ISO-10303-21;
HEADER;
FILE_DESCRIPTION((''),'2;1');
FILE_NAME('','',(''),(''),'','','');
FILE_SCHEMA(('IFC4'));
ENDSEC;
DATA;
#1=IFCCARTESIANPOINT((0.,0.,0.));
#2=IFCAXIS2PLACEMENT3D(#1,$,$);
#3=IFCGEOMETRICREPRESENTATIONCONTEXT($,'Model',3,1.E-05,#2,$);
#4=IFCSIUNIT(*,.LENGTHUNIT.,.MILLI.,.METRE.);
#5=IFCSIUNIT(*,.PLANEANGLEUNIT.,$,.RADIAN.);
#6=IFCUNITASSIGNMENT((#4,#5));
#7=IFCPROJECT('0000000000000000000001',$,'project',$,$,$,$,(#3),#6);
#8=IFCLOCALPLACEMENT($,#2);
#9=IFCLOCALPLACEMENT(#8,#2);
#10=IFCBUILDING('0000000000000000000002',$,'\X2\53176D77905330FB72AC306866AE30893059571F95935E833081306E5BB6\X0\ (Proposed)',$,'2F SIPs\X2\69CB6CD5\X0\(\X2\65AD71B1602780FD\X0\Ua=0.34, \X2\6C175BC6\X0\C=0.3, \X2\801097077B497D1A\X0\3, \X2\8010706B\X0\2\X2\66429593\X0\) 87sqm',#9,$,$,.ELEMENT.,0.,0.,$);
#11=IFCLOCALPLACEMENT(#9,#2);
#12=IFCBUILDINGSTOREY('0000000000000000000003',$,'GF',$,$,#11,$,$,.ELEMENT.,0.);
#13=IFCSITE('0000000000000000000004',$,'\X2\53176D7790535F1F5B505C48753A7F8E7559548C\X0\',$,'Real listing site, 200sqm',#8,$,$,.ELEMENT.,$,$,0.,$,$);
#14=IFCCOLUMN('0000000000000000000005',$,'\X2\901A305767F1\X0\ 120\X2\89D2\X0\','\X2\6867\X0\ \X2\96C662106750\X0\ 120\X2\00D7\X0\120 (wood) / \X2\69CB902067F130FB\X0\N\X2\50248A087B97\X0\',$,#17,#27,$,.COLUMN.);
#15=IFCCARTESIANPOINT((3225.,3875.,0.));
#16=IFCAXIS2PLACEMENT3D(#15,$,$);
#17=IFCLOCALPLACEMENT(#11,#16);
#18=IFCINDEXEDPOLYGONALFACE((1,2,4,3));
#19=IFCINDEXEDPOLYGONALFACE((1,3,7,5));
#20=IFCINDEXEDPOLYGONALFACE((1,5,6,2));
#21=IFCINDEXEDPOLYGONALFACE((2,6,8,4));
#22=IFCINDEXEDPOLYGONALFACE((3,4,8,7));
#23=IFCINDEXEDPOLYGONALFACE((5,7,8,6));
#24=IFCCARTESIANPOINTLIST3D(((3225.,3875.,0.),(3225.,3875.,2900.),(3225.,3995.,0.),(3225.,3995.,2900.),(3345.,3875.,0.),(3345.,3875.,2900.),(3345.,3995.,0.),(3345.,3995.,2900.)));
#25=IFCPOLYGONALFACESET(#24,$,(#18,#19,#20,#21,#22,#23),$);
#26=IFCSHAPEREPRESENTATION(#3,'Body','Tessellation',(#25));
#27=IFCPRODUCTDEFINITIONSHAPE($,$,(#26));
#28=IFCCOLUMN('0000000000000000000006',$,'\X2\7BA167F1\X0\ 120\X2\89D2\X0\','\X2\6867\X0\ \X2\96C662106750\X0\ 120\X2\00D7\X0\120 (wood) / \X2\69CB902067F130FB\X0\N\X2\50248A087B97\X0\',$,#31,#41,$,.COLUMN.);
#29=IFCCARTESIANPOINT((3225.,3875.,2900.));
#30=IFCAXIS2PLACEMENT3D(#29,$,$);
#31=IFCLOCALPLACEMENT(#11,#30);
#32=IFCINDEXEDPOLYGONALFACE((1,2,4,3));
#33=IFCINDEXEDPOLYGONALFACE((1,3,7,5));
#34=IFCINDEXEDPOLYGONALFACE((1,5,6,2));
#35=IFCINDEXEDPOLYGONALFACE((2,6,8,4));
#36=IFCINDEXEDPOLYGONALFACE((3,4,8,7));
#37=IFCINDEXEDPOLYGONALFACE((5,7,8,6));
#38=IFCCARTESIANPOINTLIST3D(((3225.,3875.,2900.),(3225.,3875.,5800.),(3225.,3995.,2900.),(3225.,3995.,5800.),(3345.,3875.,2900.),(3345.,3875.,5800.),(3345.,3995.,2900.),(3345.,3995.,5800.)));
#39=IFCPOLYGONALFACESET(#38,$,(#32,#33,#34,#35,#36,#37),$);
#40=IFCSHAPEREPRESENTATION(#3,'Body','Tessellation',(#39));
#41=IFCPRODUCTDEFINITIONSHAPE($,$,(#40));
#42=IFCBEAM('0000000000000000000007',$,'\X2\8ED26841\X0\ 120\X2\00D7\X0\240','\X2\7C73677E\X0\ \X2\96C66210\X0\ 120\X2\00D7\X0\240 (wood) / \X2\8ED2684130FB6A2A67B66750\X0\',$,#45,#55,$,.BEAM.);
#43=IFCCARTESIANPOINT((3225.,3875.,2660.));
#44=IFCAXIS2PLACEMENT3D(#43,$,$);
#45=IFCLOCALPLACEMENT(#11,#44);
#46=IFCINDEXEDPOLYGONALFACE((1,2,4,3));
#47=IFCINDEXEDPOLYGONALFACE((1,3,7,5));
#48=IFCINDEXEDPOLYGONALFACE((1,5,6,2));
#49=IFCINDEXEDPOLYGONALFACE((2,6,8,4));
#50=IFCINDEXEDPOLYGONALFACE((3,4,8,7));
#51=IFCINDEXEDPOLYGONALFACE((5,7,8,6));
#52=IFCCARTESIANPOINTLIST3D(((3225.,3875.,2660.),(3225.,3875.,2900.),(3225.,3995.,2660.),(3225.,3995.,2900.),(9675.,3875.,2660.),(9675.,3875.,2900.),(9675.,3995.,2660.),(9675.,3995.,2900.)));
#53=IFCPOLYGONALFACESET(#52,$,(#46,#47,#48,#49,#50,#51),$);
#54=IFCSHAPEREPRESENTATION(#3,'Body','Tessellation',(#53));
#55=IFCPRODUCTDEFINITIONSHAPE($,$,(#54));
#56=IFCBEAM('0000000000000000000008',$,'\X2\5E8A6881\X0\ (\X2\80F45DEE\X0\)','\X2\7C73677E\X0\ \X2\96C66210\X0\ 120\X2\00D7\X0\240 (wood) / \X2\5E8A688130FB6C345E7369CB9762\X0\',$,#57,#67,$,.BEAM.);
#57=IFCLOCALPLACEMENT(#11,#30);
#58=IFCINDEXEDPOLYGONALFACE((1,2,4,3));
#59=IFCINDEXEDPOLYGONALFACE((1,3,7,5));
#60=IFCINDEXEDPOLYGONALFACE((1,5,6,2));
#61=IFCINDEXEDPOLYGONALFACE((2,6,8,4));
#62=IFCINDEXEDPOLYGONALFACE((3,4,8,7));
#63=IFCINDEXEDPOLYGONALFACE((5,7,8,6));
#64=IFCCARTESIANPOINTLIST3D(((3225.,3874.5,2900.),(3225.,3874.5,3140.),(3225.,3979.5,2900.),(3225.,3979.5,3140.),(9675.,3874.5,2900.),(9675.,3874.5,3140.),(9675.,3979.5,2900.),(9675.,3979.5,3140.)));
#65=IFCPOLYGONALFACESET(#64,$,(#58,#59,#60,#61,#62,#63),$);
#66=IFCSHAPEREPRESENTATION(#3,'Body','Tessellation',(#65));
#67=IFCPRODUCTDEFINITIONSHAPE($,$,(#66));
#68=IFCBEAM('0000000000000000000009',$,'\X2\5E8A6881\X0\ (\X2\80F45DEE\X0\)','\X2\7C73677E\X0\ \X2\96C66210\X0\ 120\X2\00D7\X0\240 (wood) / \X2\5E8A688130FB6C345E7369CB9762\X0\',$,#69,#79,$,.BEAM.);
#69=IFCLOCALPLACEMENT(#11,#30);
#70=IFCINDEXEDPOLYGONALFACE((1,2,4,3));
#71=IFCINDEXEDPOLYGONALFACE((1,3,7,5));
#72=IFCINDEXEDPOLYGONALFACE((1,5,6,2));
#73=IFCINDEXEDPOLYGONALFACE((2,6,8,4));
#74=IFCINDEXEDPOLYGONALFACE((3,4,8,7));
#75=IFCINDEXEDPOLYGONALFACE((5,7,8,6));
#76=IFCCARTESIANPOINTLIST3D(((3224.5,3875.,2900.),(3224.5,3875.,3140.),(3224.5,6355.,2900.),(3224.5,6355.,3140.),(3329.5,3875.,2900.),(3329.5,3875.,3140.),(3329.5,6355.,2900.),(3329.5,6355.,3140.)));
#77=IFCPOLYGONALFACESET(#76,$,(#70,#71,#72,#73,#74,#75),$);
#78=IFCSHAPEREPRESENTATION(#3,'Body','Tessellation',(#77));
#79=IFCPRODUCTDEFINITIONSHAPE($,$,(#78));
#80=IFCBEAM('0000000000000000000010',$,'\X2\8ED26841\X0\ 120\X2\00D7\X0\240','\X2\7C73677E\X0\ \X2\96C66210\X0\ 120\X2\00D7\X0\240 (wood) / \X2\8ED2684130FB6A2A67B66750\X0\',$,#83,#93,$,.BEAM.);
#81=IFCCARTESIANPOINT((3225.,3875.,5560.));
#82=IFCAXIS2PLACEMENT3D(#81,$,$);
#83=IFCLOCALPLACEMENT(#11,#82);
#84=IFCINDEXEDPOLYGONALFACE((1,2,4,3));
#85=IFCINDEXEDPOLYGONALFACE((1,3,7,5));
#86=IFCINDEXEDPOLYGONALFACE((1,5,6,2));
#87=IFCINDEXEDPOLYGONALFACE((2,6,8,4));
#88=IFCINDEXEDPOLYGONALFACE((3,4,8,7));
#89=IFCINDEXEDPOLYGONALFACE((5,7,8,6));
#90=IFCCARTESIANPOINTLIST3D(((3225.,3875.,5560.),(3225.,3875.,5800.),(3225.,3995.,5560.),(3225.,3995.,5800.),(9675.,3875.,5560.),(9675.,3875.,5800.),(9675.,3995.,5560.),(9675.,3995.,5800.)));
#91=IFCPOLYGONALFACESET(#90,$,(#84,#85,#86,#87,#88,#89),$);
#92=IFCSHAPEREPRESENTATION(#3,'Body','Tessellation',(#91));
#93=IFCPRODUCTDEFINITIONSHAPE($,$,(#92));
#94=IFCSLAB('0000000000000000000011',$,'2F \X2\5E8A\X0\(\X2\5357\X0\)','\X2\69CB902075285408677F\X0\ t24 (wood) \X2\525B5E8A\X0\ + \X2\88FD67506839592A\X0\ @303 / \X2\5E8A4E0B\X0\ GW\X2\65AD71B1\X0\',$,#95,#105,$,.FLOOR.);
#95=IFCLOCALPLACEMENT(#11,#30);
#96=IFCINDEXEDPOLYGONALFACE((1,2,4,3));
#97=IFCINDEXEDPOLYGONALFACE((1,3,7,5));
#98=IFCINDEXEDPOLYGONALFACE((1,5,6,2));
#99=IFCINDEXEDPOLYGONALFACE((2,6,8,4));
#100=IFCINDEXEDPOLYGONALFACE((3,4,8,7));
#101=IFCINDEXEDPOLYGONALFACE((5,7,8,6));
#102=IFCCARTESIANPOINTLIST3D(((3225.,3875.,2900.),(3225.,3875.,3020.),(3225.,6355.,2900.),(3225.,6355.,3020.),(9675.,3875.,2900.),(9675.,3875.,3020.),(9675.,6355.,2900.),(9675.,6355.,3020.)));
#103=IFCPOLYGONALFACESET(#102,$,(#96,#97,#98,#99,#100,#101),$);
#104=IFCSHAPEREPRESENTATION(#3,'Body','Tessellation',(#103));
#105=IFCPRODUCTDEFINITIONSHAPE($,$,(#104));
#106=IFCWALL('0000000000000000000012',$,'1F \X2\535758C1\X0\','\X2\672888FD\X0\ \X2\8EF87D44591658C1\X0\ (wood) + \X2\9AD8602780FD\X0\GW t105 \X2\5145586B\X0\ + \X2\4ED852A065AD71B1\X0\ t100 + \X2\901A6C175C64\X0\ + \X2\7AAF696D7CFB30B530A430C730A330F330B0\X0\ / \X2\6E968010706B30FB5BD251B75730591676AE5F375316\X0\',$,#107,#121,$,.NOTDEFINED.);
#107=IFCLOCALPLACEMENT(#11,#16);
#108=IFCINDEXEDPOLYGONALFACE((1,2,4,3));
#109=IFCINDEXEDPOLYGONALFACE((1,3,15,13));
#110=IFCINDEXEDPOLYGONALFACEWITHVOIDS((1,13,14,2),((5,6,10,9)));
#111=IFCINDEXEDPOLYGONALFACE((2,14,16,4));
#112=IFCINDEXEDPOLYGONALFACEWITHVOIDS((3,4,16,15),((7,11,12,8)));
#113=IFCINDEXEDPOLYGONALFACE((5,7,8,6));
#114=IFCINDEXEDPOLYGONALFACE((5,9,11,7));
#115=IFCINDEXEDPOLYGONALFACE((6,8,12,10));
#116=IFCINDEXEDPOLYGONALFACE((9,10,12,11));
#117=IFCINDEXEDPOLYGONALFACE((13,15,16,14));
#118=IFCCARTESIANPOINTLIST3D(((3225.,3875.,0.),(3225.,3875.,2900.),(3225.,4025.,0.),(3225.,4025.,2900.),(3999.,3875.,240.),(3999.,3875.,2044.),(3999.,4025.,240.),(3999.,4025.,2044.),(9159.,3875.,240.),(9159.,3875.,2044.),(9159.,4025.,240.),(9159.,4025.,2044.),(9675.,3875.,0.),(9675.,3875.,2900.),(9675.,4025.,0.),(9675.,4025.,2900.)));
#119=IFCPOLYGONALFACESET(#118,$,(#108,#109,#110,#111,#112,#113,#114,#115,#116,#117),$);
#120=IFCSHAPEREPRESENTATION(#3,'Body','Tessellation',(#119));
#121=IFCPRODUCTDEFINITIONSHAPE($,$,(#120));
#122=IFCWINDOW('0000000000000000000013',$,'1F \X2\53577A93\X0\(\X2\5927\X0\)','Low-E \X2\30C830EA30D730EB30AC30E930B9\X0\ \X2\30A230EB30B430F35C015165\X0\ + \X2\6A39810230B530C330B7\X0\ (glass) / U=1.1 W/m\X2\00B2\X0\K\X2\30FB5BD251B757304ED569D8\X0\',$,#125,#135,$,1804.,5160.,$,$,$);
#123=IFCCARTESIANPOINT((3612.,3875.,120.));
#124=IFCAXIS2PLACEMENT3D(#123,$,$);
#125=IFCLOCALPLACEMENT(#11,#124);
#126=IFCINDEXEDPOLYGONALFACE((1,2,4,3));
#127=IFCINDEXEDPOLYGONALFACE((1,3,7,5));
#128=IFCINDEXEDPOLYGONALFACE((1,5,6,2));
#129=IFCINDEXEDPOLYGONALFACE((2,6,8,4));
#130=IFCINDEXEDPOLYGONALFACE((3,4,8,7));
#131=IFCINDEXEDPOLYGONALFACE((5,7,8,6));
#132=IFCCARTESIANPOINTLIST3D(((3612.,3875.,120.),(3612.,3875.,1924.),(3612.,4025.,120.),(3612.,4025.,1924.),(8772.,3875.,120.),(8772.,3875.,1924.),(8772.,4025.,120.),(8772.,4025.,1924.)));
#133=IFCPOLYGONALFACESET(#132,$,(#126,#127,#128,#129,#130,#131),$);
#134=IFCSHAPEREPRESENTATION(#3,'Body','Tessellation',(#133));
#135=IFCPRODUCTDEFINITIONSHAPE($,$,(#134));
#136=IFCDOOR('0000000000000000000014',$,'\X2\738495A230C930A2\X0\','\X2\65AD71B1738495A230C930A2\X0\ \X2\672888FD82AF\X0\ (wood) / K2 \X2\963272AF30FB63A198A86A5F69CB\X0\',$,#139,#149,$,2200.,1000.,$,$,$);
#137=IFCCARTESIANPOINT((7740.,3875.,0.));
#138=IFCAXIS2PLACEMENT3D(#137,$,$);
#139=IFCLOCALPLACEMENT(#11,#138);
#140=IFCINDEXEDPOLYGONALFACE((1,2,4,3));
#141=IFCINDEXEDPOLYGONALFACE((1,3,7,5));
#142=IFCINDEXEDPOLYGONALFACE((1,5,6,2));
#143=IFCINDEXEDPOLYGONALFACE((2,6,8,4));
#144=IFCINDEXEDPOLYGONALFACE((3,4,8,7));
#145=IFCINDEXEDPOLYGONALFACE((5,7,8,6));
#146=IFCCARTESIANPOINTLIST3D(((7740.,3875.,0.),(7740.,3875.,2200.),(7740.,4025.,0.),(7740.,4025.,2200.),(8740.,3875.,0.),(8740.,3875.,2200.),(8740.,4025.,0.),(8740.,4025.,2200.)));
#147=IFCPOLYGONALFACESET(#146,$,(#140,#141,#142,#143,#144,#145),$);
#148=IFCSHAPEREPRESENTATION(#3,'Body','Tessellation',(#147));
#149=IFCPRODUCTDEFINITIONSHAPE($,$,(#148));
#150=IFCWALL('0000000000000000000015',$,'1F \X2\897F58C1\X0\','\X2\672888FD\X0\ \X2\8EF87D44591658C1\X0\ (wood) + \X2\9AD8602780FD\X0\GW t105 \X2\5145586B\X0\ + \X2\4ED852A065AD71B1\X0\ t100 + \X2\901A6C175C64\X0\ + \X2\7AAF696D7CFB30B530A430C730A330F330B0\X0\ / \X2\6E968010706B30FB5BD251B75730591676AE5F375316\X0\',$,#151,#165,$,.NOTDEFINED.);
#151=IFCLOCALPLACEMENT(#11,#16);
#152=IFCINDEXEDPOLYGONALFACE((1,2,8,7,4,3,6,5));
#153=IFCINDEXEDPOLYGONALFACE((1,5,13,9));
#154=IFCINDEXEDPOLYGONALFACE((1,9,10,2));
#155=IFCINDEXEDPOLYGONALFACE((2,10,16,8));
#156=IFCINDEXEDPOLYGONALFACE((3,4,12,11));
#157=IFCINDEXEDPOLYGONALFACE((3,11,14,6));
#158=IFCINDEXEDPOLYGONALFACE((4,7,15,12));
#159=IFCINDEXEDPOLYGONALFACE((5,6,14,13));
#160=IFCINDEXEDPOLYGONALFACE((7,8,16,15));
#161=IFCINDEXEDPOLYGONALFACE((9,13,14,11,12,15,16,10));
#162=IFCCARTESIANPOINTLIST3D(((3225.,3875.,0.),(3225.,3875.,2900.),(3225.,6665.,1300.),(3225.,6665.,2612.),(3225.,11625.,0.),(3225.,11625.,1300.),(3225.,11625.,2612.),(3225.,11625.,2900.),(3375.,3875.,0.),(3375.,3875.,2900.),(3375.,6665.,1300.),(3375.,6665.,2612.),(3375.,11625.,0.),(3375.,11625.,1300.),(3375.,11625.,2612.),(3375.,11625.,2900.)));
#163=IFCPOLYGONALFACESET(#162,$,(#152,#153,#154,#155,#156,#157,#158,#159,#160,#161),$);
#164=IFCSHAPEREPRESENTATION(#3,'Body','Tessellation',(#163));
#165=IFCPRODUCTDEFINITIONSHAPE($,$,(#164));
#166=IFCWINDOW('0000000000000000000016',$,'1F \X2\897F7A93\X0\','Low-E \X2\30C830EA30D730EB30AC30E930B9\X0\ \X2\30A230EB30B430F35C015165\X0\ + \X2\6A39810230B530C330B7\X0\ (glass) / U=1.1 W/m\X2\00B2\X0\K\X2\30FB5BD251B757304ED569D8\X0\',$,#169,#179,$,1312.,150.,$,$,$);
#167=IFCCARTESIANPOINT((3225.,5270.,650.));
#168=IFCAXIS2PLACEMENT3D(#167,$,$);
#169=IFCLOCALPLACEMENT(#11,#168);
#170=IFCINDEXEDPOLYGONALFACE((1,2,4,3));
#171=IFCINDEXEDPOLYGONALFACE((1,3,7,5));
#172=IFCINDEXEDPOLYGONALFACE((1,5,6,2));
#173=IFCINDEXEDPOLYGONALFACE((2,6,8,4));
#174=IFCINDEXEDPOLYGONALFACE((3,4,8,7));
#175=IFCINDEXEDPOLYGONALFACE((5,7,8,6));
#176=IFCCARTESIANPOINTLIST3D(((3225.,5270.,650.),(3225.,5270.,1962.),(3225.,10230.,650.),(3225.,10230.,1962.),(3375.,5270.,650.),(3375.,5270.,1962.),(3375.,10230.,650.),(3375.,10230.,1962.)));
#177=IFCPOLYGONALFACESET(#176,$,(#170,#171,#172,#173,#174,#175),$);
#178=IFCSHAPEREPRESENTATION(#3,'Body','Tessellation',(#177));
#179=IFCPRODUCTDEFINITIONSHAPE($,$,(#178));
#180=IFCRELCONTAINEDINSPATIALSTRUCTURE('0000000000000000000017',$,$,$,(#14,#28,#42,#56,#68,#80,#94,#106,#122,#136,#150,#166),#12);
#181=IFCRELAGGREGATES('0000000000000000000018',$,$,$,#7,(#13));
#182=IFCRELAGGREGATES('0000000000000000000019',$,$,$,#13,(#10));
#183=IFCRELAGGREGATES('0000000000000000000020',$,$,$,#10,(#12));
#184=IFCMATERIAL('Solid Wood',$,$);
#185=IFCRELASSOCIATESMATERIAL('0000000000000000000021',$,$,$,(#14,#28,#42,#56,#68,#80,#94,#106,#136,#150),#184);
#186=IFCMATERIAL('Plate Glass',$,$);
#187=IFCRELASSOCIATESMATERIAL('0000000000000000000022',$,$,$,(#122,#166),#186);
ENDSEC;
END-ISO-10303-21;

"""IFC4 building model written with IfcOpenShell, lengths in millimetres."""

from ifc_helpers import new_model, si_unit, frame, frame_2d, origin, place, context, project, spatial, rectangle, extrude, material, element, fill, save


model = new_model("IFC4")

# Units and contexts
model_context = context("Model", 3, precision=1e-05, world=origin())
ifc_project = project(units=[si_unit("LENGTHUNIT", "METRE", prefix="MILLI"), si_unit("PLANEANGLEUNIT", "RADIAN")], contexts=[model_context])

# Site, building, storey
site_placement = place(None, origin())
site = spatial("IfcSite", under=ifc_project, at=site_placement, Name="北海道弟子屈町美留和", ObjectType="Real listing site, 200sqm", CompositionType="ELEMENT", RefElevation=0.0)
building_placement = place(site_placement, origin())
building = spatial("IfcBuilding", under=site, at=building_placement, Name="北海道・犬と暮らす土間広めの家 (Proposed)", ObjectType="2F SIPs構法(断熱性能Ua=0.34, 気密C=0.3, 耐震等級3, 耐火2時間) 87sqm", CompositionType="ELEMENT", ElevationOfRefHeight=0.0, ElevationOfTerrain=0.0)
storey_placement = place(building_placement, origin())
storey = spatial("IfcBuildingStorey", under=building, at=storey_placement, Name="GF", CompositionType="ELEMENT", Elevation=0.0)

# Columns
ifc_material_1 = material(Name="Solid Wood")
column_1_placement = place(storey_placement, frame((3225.0, 3875.0, 0.0)))
element("IfcColumn", 1, at=column_1_placement, inside=storey, material=ifc_material_1, Name="通し柱 120角", Description="桧 集成材 120×120 (wood) / 構造柱・N値計算", PredefinedType="COLUMN", context=model_context, shape_type="SweptSolid", body=[
    extrude(rectangle(XDim=120.0, YDim=120.0, at=frame_2d((60.0, 60.0))), frame((3225.0, 3875.0, 0.0)), (0.0, 0.0, 1.0), 2900.0),
])
column_2_placement = place(storey_placement, frame((3225.0, 3875.0, 2900.0)))
element("IfcColumn", 2, at=column_2_placement, inside=storey, material=ifc_material_1, Name="管柱 120角", Description="桧 集成材 120×120 (wood) / 構造柱・N値計算", PredefinedType="COLUMN", context=model_context, shape_type="SweptSolid", body=[
    extrude(rectangle(XDim=120.0, YDim=120.0, at=frame_2d((60.0, 60.0))), frame((3225.0, 3875.0, 2900.0)), (0.0, 0.0, 1.0), 2900.0),
])

# Beams
beam_1_placement = place(storey_placement, frame((3225.0, 3875.0, 2660.0)))
element("IfcBeam", 3, at=beam_1_placement, inside=storey, material=ifc_material_1, Name="軒桁 120×240", Description="米松 集成 120×240 (wood) / 軒桁・横架材", PredefinedType="BEAM", context=model_context, shape_type="SweptSolid", body=[
    extrude(rectangle(XDim=6450.0, YDim=120.0, at=frame_2d((3225.0, 60.0))), frame((3225.0, 3875.0, 2660.0)), (0.0, 0.0, 1.0), 240.0),
])
beam_2_placement = place(storey_placement, frame((3225.0, 3875.0, 2900.0)))
element("IfcBeam", 4, at=beam_2_placement, inside=storey, material=ifc_material_1, Name="床梁 (胴差)", Description="米松 集成 120×240 (wood) / 床梁・水平構面", PredefinedType="BEAM", context=model_context, shape_type="SweptSolid", body=[
    extrude(rectangle(XDim=6450.0, YDim=105.0, at=frame_2d((3225.0, 52.0))), frame((3225.0, 3875.0, 2900.0)), (0.0, 0.0, 1.0), 240.0),
])
beam_3_placement = place(storey_placement, frame((3225.0, 3875.0, 2900.0)))
element("IfcBeam", 5, at=beam_3_placement, inside=storey, material=ifc_material_1, Name="床梁 (胴差)", Description="米松 集成 120×240 (wood) / 床梁・水平構面", PredefinedType="BEAM", context=model_context, shape_type="SweptSolid", body=[
    extrude(rectangle(XDim=105.0, YDim=2480.0, at=frame_2d((52.0, 1240.0))), frame((3225.0, 3875.0, 2900.0)), (0.0, 0.0, 1.0), 240.0),
])
beam_4_placement = place(storey_placement, frame((3225.0, 3875.0, 5560.0)))
element("IfcBeam", 6, at=beam_4_placement, inside=storey, material=ifc_material_1, Name="軒桁 120×240", Description="米松 集成 120×240 (wood) / 軒桁・横架材", PredefinedType="BEAM", context=model_context, shape_type="SweptSolid", body=[
    extrude(rectangle(XDim=6450.0, YDim=120.0, at=frame_2d((3225.0, 60.0))), frame((3225.0, 3875.0, 5560.0)), (0.0, 0.0, 1.0), 240.0),
])

# Slab
slab_1_placement = place(storey_placement, frame((3225.0, 3875.0, 2900.0)))
element("IfcSlab", 7, at=slab_1_placement, inside=storey, material=ifc_material_1, Name="2F 床(南)", Description="構造用合板 t24 (wood) 剛床 + 製材根太 @303 / 床下 GW断熱", PredefinedType="FLOOR", context=model_context, shape_type="SweptSolid", body=[
    extrude(rectangle(XDim=6450.0, YDim=2480.0, at=frame_2d((3225.0, 1240.0))), frame((3225.0, 3875.0, 2900.0)), (0.0, 0.0, 1.0), 120.0),
])

# Wall, openings, window, door
wall_1_placement = place(storey_placement, frame((3225.0, 3875.0, 0.0)))
wall_1 = element("IfcWall", 8, at=wall_1_placement, inside=storey, material=ifc_material_1, Name="1F 南壁", Description="木製 軸組外壁 (wood) + 高性能GW t105 充填 + 付加断熱 t100 + 通気層 + 窯業系サイディング / 準耐火・寒冷地外皮強化", PredefinedType="NOTDEFINED", context=model_context, shape_type="SweptSolid", body=[
    extrude(rectangle(XDim=6450.0, YDim=150.0, at=frame_2d((3225.0, 75.0))), frame((3225.0, 3875.0, 0.0)), (0.0, 0.0, 1.0), 2900.0),
])
opening_1_placement = place(storey_placement, frame((3612.0, 3875.0, 120.0)))
opening_1 = element("IfcOpeningElement", 9, at=opening_1_placement, cuts=wall_1, PredefinedType="NOTDEFINED", context=model_context, shape_type="SweptSolid", body=[
    extrude(rectangle(XDim=5160.0, YDim=150.0, at=frame_2d((2580.0, 75.0))), frame((3612.0, 3875.0, 120.0)), (0.0, 0.0, 1.0), 1804.0),
])
opening_2_placement = place(storey_placement, frame((7740.0, 3875.0, 0.0)))
opening_2 = element("IfcOpeningElement", 10, at=opening_2_placement, cuts=wall_1, PredefinedType="NOTDEFINED", context=model_context, shape_type="SweptSolid", body=[
    extrude(rectangle(XDim=1000.0, YDim=150.0, at=frame_2d((500.0, 75.0))), frame((7740.0, 3875.0, 0.0)), (0.0, 0.0, 1.0), 2200.0),
])
ifc_material_2 = material(Name="Plate Glass")
window_1_placement = place(storey_placement, frame((3612.0, 3875.0, 120.0)))
window_1 = element("IfcWindow", 11, at=window_1_placement, inside=storey, material=ifc_material_2, Name="1F 南窓(大)", Description="Low-E トリプルガラス アルゴン封入 + 樹脂サッシ (glass) / U=1.1 W/m²K・寒冷地仕様", OverallHeight=1804.0, OverallWidth=5160.0, context=model_context, shape_type="SweptSolid", body=[
    extrude(rectangle(XDim=5160.0, YDim=150.0, at=frame_2d((2580.0, 75.0))), frame((3612.0, 3875.0, 120.0)), (0.0, 0.0, 1.0), 1804.0),
])
fill(opening_1, window_1)
door_placement = place(storey_placement, frame((7740.0, 3875.0, 0.0)))
door = element("IfcDoor", 12, at=door_placement, inside=storey, material=ifc_material_1, Name="玄関ドア", Description="断熱玄関ドア 木製芯 (wood) / K2 防犯・採風機構", OverallHeight=2200.0, OverallWidth=1000.0, context=model_context, shape_type="SweptSolid", body=[
    extrude(rectangle(XDim=1000.0, YDim=150.0, at=frame_2d((500.0, 75.0))), frame((7740.0, 3875.0, 0.0)), (0.0, 0.0, 1.0), 2200.0),
])
fill(opening_2, door)

# Wall, opening, window
wall_2_placement = place(storey_placement, frame((3225.0, 3875.0, 0.0)))
wall_2 = element("IfcWall", 13, at=wall_2_placement, inside=storey, material=ifc_material_1, Name="1F 西壁", Description="木製 軸組外壁 (wood) + 高性能GW t105 充填 + 付加断熱 t100 + 通気層 + 窯業系サイディング / 準耐火・寒冷地外皮強化", PredefinedType="NOTDEFINED", context=model_context, shape_type="SweptSolid", body=[
    extrude(rectangle(XDim=150.0, YDim=7750.0, at=frame_2d((75.0, 3875.0))), frame((3225.0, 3875.0, 0.0)), (0.0, 0.0, 1.0), 2900.0),
])
opening_3_placement = place(storey_placement, frame((3225.0, 5270.0, 650.0)))
opening_3 = element("IfcOpeningElement", 14, at=opening_3_placement, cuts=wall_2, PredefinedType="NOTDEFINED", context=model_context, shape_type="SweptSolid", body=[
    extrude(rectangle(XDim=150.0, YDim=4960.0, at=frame_2d((75.0, 2480.0))), frame((3225.0, 5270.0, 650.0)), (0.0, 0.0, 1.0), 1312.0),
])
window_2_placement = place(storey_placement, frame((3225.0, 5270.0, 650.0)))
window_2 = element("IfcWindow", 15, at=window_2_placement, inside=storey, material=ifc_material_2, Name="1F 西窓", Description="Low-E トリプルガラス アルゴン封入 + 樹脂サッシ (glass) / U=1.1 W/m²K・寒冷地仕様", OverallHeight=1312.0, OverallWidth=150.0, context=model_context, shape_type="SweptSolid", body=[
    extrude(rectangle(XDim=150.0, YDim=4960.0, at=frame_2d((75.0, 2480.0))), frame((3225.0, 5270.0, 650.0)), (0.0, 0.0, 1.0), 1312.0),
])
fill(opening_3, window_2)

save(model, "model.ifc")
